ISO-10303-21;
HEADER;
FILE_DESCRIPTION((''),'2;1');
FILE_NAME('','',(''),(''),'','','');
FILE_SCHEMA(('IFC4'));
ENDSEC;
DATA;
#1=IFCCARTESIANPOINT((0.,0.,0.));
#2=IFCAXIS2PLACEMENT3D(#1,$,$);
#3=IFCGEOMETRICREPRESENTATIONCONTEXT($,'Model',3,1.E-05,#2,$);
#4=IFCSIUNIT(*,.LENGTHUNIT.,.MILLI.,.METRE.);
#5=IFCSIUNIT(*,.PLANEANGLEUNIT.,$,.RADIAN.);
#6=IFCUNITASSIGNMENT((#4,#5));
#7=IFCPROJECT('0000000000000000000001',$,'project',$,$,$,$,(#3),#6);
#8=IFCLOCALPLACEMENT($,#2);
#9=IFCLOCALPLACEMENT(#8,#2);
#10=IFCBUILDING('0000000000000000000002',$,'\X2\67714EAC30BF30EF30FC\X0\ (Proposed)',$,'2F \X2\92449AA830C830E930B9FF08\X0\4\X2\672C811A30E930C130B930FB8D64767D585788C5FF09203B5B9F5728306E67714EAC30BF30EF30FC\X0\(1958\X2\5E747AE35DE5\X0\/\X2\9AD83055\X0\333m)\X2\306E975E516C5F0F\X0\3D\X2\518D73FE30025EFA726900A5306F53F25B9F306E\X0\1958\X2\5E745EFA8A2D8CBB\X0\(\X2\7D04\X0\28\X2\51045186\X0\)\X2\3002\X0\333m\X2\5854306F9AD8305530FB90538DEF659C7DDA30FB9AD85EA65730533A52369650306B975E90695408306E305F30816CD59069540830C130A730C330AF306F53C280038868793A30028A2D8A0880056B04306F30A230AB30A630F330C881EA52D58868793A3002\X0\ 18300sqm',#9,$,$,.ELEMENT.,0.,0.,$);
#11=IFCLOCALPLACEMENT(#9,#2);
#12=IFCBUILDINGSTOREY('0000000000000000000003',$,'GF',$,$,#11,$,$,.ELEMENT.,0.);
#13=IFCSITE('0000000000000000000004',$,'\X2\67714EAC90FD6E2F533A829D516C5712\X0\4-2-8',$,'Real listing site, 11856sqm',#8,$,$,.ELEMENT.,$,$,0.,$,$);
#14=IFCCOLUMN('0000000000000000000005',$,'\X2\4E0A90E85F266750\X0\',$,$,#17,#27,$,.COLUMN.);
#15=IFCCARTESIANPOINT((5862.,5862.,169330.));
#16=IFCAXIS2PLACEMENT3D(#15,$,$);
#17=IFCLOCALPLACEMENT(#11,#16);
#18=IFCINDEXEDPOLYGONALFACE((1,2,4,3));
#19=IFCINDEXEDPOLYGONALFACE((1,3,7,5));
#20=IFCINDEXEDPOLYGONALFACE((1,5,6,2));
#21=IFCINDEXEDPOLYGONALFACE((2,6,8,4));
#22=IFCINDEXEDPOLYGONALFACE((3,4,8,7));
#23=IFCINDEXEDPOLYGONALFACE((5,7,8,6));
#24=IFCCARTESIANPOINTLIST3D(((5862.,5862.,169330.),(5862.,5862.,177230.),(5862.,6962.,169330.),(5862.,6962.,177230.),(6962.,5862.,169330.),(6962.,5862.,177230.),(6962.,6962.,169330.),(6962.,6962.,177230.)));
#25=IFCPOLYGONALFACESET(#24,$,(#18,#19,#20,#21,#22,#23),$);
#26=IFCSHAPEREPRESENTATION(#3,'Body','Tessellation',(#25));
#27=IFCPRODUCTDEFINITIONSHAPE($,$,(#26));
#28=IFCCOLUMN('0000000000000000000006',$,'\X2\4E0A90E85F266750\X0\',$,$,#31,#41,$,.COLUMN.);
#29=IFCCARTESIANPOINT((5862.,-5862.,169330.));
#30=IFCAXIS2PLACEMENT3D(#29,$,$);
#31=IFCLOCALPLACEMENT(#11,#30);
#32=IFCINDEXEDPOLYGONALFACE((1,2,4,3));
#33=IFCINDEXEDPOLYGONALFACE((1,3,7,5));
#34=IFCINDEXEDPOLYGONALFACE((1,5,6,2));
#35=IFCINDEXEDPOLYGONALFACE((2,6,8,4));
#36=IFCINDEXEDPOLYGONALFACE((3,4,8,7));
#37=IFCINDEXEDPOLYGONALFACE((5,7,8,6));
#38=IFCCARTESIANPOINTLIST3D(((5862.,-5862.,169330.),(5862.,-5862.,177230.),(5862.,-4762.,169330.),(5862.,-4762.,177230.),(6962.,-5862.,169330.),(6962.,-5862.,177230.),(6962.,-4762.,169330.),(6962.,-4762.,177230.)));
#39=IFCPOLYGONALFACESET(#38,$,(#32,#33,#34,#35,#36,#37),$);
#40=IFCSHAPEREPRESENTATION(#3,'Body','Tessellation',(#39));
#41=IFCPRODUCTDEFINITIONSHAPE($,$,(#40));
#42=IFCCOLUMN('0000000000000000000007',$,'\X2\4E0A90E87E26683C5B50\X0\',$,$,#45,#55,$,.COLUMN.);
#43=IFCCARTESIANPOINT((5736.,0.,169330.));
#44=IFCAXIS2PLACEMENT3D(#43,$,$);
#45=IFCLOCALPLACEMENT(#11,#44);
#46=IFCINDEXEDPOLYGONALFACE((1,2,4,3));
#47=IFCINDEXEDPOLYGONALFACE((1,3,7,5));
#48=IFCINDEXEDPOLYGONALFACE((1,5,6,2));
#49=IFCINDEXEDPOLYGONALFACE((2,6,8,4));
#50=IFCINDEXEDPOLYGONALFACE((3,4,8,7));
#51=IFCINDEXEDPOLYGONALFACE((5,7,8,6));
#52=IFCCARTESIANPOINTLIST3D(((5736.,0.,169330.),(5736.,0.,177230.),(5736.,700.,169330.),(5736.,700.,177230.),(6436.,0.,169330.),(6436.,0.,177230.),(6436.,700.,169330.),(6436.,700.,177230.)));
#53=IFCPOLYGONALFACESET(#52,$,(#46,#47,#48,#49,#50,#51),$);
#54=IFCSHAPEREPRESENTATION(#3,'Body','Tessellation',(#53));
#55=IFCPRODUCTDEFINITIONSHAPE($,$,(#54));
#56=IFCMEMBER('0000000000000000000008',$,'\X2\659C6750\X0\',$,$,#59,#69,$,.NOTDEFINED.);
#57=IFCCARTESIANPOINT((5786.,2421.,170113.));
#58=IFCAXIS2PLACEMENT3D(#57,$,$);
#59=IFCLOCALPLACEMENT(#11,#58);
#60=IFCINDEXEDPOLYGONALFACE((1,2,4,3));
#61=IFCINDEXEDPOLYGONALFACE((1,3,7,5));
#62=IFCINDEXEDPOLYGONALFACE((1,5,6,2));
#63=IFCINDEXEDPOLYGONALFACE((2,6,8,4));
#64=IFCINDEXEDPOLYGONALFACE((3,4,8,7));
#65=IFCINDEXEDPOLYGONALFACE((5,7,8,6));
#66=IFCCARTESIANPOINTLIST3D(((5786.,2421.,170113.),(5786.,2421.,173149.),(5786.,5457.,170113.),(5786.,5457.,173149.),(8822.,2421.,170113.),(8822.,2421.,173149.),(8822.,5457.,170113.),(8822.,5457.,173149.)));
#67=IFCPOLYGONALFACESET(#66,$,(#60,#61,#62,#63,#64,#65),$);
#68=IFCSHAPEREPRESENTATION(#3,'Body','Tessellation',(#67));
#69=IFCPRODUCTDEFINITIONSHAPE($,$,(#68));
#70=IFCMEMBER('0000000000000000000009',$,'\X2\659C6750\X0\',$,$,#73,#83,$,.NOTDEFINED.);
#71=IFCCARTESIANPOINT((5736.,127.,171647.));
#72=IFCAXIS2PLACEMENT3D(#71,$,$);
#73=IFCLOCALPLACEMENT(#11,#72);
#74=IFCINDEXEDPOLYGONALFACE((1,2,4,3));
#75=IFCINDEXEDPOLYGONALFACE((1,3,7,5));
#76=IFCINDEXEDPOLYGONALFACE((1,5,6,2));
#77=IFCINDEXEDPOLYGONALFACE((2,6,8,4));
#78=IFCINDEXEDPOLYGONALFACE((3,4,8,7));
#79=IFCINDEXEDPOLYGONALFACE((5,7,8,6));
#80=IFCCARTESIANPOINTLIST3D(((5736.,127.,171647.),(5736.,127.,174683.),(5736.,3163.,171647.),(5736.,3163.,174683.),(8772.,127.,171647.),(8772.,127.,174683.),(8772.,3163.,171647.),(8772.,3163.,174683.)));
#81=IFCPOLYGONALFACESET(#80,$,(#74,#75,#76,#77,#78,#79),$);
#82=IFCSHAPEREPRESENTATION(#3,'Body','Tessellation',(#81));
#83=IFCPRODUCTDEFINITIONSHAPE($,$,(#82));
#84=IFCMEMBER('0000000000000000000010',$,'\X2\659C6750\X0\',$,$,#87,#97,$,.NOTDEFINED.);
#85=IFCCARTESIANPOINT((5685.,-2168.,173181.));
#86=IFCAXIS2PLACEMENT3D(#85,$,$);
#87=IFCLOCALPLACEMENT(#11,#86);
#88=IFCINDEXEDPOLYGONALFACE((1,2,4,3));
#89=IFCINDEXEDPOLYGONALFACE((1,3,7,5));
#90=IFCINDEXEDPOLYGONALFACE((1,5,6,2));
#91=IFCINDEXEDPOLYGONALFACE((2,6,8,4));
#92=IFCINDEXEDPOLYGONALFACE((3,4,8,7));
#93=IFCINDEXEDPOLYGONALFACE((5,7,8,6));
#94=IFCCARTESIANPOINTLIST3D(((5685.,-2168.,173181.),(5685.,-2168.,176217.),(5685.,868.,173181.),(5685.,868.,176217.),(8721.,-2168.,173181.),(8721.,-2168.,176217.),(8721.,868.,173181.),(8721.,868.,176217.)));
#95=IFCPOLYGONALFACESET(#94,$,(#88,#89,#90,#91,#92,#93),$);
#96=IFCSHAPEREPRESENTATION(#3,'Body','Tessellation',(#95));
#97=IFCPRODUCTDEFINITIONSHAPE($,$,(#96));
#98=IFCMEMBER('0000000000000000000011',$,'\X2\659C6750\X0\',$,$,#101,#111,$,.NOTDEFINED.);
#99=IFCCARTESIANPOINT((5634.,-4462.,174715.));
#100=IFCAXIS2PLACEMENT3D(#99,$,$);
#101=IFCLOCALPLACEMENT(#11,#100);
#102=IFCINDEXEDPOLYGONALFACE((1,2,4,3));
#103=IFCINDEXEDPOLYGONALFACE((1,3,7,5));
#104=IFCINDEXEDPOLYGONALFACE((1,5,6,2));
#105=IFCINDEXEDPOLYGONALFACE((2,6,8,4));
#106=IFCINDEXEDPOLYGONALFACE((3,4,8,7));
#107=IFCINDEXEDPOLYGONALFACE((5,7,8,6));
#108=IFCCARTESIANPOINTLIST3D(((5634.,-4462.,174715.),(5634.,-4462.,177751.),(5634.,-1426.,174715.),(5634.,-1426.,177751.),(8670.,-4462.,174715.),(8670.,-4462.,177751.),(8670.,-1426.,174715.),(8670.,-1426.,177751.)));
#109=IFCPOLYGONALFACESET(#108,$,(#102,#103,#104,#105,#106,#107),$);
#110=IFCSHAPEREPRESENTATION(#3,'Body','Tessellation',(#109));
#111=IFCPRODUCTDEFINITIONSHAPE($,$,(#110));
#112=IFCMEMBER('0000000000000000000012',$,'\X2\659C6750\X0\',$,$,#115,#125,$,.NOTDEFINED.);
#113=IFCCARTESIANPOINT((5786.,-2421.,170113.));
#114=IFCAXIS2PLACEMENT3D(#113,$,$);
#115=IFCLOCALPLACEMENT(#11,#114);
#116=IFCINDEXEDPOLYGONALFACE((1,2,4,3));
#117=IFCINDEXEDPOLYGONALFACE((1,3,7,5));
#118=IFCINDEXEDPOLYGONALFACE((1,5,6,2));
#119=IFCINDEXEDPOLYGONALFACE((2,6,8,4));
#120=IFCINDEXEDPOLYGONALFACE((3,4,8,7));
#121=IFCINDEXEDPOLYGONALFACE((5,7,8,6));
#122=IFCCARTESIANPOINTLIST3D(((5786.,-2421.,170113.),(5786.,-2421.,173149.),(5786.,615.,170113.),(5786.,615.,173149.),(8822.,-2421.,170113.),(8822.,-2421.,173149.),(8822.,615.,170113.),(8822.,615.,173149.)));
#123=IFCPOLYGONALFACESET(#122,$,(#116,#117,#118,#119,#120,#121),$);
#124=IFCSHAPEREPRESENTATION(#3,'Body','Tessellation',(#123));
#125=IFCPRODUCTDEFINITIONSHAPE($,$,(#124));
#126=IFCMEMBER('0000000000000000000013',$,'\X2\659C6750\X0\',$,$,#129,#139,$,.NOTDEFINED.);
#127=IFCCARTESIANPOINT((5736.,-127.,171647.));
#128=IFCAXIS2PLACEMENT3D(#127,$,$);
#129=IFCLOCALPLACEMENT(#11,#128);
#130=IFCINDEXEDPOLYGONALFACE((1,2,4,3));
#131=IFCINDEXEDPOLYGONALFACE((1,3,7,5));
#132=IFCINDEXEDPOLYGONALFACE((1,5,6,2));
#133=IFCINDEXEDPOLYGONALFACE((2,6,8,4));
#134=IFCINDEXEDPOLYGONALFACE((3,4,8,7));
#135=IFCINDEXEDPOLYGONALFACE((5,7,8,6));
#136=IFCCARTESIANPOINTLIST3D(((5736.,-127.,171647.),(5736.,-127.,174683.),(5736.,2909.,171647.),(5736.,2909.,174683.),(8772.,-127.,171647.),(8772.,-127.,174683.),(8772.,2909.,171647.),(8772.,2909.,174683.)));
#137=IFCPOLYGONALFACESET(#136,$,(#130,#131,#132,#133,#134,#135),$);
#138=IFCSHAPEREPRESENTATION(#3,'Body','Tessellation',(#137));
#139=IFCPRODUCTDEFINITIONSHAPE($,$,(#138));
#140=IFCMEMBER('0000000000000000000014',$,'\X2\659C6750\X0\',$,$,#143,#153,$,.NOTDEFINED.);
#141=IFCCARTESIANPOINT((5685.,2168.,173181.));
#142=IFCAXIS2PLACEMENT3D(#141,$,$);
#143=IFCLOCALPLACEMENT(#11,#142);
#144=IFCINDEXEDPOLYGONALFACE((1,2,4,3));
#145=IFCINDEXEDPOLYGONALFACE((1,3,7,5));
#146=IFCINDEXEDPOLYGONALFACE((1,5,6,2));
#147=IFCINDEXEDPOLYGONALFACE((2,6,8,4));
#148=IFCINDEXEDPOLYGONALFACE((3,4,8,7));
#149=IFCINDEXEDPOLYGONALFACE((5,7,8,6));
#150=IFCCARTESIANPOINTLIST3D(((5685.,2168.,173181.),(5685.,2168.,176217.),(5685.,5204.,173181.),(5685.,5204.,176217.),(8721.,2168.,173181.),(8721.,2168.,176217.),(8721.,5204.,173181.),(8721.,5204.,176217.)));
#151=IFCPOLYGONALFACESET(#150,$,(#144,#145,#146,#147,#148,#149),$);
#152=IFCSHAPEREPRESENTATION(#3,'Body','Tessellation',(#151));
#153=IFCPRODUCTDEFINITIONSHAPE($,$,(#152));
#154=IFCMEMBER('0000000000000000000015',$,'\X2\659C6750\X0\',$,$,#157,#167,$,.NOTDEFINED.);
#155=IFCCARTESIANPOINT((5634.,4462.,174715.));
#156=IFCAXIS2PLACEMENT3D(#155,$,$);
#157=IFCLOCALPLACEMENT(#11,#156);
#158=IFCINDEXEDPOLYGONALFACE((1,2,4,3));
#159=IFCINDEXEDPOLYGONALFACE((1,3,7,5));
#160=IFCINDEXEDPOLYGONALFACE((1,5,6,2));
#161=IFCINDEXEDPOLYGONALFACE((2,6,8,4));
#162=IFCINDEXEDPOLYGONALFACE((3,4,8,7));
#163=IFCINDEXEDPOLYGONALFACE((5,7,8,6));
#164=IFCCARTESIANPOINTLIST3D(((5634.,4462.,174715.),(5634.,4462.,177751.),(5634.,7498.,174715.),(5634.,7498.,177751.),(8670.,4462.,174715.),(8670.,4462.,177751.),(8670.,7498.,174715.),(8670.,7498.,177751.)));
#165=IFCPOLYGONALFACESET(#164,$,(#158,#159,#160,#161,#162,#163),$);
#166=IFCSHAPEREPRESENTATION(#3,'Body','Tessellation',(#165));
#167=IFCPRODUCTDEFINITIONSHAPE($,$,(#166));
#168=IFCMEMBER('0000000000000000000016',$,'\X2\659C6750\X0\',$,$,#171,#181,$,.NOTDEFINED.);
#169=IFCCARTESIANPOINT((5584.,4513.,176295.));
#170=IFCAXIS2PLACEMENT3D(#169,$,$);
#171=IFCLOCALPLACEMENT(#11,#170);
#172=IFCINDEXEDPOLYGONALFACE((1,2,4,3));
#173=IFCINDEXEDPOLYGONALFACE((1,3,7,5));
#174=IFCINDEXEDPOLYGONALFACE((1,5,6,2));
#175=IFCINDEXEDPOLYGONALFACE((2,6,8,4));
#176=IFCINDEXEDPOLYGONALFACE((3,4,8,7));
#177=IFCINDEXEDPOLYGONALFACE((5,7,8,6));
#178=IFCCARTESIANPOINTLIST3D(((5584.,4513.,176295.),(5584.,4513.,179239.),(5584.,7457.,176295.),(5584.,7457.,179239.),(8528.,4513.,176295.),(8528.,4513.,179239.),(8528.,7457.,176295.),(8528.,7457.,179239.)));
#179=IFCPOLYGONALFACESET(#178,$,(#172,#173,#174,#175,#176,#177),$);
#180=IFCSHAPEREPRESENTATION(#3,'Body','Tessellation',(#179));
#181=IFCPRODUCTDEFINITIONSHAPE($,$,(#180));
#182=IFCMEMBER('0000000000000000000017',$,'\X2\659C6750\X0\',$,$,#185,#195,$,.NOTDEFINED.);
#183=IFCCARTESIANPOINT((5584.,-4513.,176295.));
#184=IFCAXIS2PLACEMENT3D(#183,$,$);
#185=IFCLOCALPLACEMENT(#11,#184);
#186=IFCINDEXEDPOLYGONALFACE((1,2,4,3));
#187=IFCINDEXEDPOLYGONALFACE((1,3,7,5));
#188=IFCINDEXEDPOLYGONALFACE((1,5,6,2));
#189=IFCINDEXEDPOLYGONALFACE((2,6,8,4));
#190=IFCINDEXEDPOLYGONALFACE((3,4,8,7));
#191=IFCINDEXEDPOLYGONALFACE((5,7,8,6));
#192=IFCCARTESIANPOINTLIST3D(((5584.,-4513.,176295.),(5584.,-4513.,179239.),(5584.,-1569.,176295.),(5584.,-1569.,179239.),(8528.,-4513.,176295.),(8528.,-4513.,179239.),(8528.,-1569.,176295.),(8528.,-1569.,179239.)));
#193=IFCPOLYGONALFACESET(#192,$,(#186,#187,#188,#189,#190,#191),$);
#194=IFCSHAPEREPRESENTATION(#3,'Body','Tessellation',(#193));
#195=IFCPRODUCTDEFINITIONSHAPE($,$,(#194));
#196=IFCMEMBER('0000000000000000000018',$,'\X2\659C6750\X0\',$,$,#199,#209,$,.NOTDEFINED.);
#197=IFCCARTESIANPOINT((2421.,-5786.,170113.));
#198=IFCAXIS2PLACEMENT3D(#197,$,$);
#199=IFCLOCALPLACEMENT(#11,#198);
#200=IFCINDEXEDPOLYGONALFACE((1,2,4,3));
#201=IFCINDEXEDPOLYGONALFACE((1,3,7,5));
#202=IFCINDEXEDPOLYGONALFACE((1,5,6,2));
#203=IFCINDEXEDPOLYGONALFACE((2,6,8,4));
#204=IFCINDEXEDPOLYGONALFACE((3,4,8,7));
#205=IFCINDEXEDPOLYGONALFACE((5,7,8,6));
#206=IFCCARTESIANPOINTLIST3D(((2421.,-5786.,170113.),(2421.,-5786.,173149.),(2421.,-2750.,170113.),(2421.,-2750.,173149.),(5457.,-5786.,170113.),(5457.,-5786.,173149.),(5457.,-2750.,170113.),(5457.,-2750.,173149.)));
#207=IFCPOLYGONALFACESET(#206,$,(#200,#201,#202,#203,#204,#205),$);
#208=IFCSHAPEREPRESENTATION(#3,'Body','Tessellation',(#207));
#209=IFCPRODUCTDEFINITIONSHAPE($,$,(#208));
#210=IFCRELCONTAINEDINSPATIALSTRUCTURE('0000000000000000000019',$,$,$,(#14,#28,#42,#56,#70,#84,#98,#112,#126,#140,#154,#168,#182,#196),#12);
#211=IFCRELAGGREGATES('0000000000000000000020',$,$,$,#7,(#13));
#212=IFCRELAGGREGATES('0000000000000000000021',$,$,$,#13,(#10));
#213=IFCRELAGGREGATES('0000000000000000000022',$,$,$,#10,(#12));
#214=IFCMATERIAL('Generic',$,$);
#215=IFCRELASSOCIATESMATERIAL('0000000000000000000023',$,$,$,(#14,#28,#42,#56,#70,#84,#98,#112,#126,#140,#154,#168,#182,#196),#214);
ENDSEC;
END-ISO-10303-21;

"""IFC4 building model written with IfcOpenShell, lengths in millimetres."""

from ifc_helpers import new_model, si_unit, frame, frame_2d, origin, place, context, project, spatial, rectangle, extrude, material, element, save


model = new_model("IFC4")

# Units and contexts
model_context = context("Model", 3, precision=1e-05, world=origin())
ifc_project = project(units=[si_unit("LENGTHUNIT", "METRE", prefix="MILLI"), si_unit("PLANEANGLEUNIT", "RADIAN")], contexts=[model_context])

# Site, building, storey
site_placement = place(None, origin())
site = spatial("IfcSite", under=ifc_project, at=site_placement, Name="東京都港区芝公園4-2-8", ObjectType="Real listing site, 11856sqm", CompositionType="ELEMENT", RefElevation=0.0)
building_placement = place(site_placement, origin())
building = spatial("IfcBuilding", under=site, at=building_placement, Name="東京タワー (Proposed)", ObjectType="2F 鉄骨トラス（4本脚ラチス・赤白塗装）※実在の東京タワー(1958年竣工/高さ333m)の非公式3D再現。建物¥は史実の1958年建設費(約28億円)。333m塔は高さ・道路斜線・高度地区制限に非適合のため法適合チェックは参考表示。設計者欄はアカウント自動表示。 18300sqm", CompositionType="ELEMENT", ElevationOfRefHeight=0.0, ElevationOfTerrain=0.0)
storey_placement = place(building_placement, origin())
storey = spatial("IfcBuildingStorey", under=building, at=storey_placement, Name="GF", CompositionType="ELEMENT", Elevation=0.0)

# Columns
ifc_material = material(Name="Generic")
column_1_placement = place(storey_placement, frame((5862.0, 5862.0, 169330.0)))
element("IfcColumn", 1, at=column_1_placement, inside=storey, material=ifc_material, Name="上部弦材", PredefinedType="COLUMN", context=model_context, shape_type="SweptSolid", body=[
    extrude(rectangle(XDim=1100.0, YDim=1100.0, at=frame_2d((550.0, 550.0))), frame((5862.0, 5862.0, 169330.0)), (0.0, 0.0, 1.0), 7900.0),
])
column_2_placement = place(storey_placement, frame((5862.0, -5862.0, 169330.0)))
element("IfcColumn", 2, at=column_2_placement, inside=storey, material=ifc_material, Name="上部弦材", PredefinedType="COLUMN", context=model_context, shape_type="SweptSolid", body=[
    extrude(rectangle(XDim=1100.0, YDim=1100.0, at=frame_2d((550.0, 550.0))), frame((5862.0, -5862.0, 169330.0)), (0.0, 0.0, 1.0), 7900.0),
])
column_3_placement = place(storey_placement, frame((5736.0, 0.0, 169330.0)))
element("IfcColumn", 3, at=column_3_placement, inside=storey, material=ifc_material, Name="上部縦格子", PredefinedType="COLUMN", context=model_context, shape_type="SweptSolid", body=[
    extrude(rectangle(XDim=700.0, YDim=700.0, at=frame_2d((350.0, 350.0))), frame((5736.0, 0.0, 169330.0)), (0.0, 0.0, 1.0), 7900.0),
])

# Members
member_1_placement = place(storey_placement, frame((5786.0, 2421.0, 170113.0)))
element("IfcMember", 4, at=member_1_placement, inside=storey, material=ifc_material, Name="斜材", PredefinedType="NOTDEFINED", context=model_context, shape_type="SweptSolid", body=[
    extrude(rectangle(XDim=3036.0, YDim=3036.0, at=frame_2d((1518.0, 1518.0))), frame((5786.0, 2421.0, 170113.0)), (0.0, 0.0, 1.0), 3036.0),
])
member_2_placement = place(storey_placement, frame((5736.0, 127.0, 171647.0)))
element("IfcMember", 5, at=member_2_placement, inside=storey, material=ifc_material, Name="斜材", PredefinedType="NOTDEFINED", context=model_context, shape_type="SweptSolid", body=[
    extrude(rectangle(XDim=3036.0, YDim=3036.0, at=frame_2d((1518.0, 1518.0))), frame((5736.0, 127.0, 171647.0)), (0.0, 0.0, 1.0), 3036.0),
])
member_3_placement = place(storey_placement, frame((5685.0, -2168.0, 173181.0)))
element("IfcMember", 6, at=member_3_placement, inside=storey, material=ifc_material, Name="斜材", PredefinedType="NOTDEFINED", context=model_context, shape_type="SweptSolid", body=[
    extrude(rectangle(XDim=3036.0, YDim=3036.0, at=frame_2d((1518.0, 1518.0))), frame((5685.0, -2168.0, 173181.0)), (0.0, 0.0, 1.0), 3036.0),
])
member_4_placement = place(storey_placement, frame((5634.0, -4462.0, 174715.0)))
element("IfcMember", 7, at=member_4_placement, inside=storey, material=ifc_material, Name="斜材", PredefinedType="NOTDEFINED", context=model_context, shape_type="SweptSolid", body=[
    extrude(rectangle(XDim=3036.0, YDim=3036.0, at=frame_2d((1518.0, 1518.0))), frame((5634.0, -4462.0, 174715.0)), (0.0, 0.0, 1.0), 3036.0),
])
member_5_placement = place(storey_placement, frame((5786.0, -2421.0, 170113.0)))
element("IfcMember", 8, at=member_5_placement, inside=storey, material=ifc_material, Name="斜材", PredefinedType="NOTDEFINED", context=model_context, shape_type="SweptSolid", body=[
    extrude(rectangle(XDim=3036.0, YDim=3036.0, at=frame_2d((1518.0, 1518.0))), frame((5786.0, -2421.0, 170113.0)), (0.0, 0.0, 1.0), 3036.0),
])
member_6_placement = place(storey_placement, frame((5736.0, -127.0, 171647.0)))
element("IfcMember", 9, at=member_6_placement, inside=storey, material=ifc_material, Name="斜材", PredefinedType="NOTDEFINED", context=model_context, shape_type="SweptSolid", body=[
    extrude(rectangle(XDim=3036.0, YDim=3036.0, at=frame_2d((1518.0, 1518.0))), frame((5736.0, -127.0, 171647.0)), (0.0, 0.0, 1.0), 3036.0),
])
member_7_placement = place(storey_placement, frame((5685.0, 2168.0, 173181.0)))
element("IfcMember", 10, at=member_7_placement, inside=storey, material=ifc_material, Name="斜材", PredefinedType="NOTDEFINED", context=model_context, shape_type="SweptSolid", body=[
    extrude(rectangle(XDim=3036.0, YDim=3036.0, at=frame_2d((1518.0, 1518.0))), frame((5685.0, 2168.0, 173181.0)), (0.0, 0.0, 1.0), 3036.0),
])
member_8_placement = place(storey_placement, frame((5634.0, 4462.0, 174715.0)))
element("IfcMember", 11, at=member_8_placement, inside=storey, material=ifc_material, Name="斜材", PredefinedType="NOTDEFINED", context=model_context, shape_type="SweptSolid", body=[
    extrude(rectangle(XDim=3036.0, YDim=3036.0, at=frame_2d((1518.0, 1518.0))), frame((5634.0, 4462.0, 174715.0)), (0.0, 0.0, 1.0), 3036.0),
])
member_9_placement = place(storey_placement, frame((5584.0, 4513.0, 176295.0)))
element("IfcMember", 12, at=member_9_placement, inside=storey, material=ifc_material, Name="斜材", PredefinedType="NOTDEFINED", context=model_context, shape_type="SweptSolid", body=[
    extrude(rectangle(XDim=2944.0, YDim=2944.0, at=frame_2d((1472.0, 1472.0))), frame((5584.0, 4513.0, 176295.0)), (0.0, 0.0, 1.0), 2944.0),
])
member_10_placement = place(storey_placement, frame((5584.0, -4513.0, 176295.0)))
element("IfcMember", 13, at=member_10_placement, inside=storey, material=ifc_material, Name="斜材", PredefinedType="NOTDEFINED", context=model_context, shape_type="SweptSolid", body=[
    extrude(rectangle(XDim=2944.0, YDim=2944.0, at=frame_2d((1472.0, 1472.0))), frame((5584.0, -4513.0, 176295.0)), (0.0, 0.0, 1.0), 2944.0),
])
member_11_placement = place(storey_placement, frame((2421.0, -5786.0, 170113.0)))
element("IfcMember", 14, at=member_11_placement, inside=storey, material=ifc_material, Name="斜材", PredefinedType="NOTDEFINED", context=model_context, shape_type="SweptSolid", body=[
    extrude(rectangle(XDim=3036.0, YDim=3036.0, at=frame_2d((1518.0, 1518.0))), frame((2421.0, -5786.0, 170113.0)), (0.0, 0.0, 1.0), 3036.0),
])

save(model, "model.ifc")
